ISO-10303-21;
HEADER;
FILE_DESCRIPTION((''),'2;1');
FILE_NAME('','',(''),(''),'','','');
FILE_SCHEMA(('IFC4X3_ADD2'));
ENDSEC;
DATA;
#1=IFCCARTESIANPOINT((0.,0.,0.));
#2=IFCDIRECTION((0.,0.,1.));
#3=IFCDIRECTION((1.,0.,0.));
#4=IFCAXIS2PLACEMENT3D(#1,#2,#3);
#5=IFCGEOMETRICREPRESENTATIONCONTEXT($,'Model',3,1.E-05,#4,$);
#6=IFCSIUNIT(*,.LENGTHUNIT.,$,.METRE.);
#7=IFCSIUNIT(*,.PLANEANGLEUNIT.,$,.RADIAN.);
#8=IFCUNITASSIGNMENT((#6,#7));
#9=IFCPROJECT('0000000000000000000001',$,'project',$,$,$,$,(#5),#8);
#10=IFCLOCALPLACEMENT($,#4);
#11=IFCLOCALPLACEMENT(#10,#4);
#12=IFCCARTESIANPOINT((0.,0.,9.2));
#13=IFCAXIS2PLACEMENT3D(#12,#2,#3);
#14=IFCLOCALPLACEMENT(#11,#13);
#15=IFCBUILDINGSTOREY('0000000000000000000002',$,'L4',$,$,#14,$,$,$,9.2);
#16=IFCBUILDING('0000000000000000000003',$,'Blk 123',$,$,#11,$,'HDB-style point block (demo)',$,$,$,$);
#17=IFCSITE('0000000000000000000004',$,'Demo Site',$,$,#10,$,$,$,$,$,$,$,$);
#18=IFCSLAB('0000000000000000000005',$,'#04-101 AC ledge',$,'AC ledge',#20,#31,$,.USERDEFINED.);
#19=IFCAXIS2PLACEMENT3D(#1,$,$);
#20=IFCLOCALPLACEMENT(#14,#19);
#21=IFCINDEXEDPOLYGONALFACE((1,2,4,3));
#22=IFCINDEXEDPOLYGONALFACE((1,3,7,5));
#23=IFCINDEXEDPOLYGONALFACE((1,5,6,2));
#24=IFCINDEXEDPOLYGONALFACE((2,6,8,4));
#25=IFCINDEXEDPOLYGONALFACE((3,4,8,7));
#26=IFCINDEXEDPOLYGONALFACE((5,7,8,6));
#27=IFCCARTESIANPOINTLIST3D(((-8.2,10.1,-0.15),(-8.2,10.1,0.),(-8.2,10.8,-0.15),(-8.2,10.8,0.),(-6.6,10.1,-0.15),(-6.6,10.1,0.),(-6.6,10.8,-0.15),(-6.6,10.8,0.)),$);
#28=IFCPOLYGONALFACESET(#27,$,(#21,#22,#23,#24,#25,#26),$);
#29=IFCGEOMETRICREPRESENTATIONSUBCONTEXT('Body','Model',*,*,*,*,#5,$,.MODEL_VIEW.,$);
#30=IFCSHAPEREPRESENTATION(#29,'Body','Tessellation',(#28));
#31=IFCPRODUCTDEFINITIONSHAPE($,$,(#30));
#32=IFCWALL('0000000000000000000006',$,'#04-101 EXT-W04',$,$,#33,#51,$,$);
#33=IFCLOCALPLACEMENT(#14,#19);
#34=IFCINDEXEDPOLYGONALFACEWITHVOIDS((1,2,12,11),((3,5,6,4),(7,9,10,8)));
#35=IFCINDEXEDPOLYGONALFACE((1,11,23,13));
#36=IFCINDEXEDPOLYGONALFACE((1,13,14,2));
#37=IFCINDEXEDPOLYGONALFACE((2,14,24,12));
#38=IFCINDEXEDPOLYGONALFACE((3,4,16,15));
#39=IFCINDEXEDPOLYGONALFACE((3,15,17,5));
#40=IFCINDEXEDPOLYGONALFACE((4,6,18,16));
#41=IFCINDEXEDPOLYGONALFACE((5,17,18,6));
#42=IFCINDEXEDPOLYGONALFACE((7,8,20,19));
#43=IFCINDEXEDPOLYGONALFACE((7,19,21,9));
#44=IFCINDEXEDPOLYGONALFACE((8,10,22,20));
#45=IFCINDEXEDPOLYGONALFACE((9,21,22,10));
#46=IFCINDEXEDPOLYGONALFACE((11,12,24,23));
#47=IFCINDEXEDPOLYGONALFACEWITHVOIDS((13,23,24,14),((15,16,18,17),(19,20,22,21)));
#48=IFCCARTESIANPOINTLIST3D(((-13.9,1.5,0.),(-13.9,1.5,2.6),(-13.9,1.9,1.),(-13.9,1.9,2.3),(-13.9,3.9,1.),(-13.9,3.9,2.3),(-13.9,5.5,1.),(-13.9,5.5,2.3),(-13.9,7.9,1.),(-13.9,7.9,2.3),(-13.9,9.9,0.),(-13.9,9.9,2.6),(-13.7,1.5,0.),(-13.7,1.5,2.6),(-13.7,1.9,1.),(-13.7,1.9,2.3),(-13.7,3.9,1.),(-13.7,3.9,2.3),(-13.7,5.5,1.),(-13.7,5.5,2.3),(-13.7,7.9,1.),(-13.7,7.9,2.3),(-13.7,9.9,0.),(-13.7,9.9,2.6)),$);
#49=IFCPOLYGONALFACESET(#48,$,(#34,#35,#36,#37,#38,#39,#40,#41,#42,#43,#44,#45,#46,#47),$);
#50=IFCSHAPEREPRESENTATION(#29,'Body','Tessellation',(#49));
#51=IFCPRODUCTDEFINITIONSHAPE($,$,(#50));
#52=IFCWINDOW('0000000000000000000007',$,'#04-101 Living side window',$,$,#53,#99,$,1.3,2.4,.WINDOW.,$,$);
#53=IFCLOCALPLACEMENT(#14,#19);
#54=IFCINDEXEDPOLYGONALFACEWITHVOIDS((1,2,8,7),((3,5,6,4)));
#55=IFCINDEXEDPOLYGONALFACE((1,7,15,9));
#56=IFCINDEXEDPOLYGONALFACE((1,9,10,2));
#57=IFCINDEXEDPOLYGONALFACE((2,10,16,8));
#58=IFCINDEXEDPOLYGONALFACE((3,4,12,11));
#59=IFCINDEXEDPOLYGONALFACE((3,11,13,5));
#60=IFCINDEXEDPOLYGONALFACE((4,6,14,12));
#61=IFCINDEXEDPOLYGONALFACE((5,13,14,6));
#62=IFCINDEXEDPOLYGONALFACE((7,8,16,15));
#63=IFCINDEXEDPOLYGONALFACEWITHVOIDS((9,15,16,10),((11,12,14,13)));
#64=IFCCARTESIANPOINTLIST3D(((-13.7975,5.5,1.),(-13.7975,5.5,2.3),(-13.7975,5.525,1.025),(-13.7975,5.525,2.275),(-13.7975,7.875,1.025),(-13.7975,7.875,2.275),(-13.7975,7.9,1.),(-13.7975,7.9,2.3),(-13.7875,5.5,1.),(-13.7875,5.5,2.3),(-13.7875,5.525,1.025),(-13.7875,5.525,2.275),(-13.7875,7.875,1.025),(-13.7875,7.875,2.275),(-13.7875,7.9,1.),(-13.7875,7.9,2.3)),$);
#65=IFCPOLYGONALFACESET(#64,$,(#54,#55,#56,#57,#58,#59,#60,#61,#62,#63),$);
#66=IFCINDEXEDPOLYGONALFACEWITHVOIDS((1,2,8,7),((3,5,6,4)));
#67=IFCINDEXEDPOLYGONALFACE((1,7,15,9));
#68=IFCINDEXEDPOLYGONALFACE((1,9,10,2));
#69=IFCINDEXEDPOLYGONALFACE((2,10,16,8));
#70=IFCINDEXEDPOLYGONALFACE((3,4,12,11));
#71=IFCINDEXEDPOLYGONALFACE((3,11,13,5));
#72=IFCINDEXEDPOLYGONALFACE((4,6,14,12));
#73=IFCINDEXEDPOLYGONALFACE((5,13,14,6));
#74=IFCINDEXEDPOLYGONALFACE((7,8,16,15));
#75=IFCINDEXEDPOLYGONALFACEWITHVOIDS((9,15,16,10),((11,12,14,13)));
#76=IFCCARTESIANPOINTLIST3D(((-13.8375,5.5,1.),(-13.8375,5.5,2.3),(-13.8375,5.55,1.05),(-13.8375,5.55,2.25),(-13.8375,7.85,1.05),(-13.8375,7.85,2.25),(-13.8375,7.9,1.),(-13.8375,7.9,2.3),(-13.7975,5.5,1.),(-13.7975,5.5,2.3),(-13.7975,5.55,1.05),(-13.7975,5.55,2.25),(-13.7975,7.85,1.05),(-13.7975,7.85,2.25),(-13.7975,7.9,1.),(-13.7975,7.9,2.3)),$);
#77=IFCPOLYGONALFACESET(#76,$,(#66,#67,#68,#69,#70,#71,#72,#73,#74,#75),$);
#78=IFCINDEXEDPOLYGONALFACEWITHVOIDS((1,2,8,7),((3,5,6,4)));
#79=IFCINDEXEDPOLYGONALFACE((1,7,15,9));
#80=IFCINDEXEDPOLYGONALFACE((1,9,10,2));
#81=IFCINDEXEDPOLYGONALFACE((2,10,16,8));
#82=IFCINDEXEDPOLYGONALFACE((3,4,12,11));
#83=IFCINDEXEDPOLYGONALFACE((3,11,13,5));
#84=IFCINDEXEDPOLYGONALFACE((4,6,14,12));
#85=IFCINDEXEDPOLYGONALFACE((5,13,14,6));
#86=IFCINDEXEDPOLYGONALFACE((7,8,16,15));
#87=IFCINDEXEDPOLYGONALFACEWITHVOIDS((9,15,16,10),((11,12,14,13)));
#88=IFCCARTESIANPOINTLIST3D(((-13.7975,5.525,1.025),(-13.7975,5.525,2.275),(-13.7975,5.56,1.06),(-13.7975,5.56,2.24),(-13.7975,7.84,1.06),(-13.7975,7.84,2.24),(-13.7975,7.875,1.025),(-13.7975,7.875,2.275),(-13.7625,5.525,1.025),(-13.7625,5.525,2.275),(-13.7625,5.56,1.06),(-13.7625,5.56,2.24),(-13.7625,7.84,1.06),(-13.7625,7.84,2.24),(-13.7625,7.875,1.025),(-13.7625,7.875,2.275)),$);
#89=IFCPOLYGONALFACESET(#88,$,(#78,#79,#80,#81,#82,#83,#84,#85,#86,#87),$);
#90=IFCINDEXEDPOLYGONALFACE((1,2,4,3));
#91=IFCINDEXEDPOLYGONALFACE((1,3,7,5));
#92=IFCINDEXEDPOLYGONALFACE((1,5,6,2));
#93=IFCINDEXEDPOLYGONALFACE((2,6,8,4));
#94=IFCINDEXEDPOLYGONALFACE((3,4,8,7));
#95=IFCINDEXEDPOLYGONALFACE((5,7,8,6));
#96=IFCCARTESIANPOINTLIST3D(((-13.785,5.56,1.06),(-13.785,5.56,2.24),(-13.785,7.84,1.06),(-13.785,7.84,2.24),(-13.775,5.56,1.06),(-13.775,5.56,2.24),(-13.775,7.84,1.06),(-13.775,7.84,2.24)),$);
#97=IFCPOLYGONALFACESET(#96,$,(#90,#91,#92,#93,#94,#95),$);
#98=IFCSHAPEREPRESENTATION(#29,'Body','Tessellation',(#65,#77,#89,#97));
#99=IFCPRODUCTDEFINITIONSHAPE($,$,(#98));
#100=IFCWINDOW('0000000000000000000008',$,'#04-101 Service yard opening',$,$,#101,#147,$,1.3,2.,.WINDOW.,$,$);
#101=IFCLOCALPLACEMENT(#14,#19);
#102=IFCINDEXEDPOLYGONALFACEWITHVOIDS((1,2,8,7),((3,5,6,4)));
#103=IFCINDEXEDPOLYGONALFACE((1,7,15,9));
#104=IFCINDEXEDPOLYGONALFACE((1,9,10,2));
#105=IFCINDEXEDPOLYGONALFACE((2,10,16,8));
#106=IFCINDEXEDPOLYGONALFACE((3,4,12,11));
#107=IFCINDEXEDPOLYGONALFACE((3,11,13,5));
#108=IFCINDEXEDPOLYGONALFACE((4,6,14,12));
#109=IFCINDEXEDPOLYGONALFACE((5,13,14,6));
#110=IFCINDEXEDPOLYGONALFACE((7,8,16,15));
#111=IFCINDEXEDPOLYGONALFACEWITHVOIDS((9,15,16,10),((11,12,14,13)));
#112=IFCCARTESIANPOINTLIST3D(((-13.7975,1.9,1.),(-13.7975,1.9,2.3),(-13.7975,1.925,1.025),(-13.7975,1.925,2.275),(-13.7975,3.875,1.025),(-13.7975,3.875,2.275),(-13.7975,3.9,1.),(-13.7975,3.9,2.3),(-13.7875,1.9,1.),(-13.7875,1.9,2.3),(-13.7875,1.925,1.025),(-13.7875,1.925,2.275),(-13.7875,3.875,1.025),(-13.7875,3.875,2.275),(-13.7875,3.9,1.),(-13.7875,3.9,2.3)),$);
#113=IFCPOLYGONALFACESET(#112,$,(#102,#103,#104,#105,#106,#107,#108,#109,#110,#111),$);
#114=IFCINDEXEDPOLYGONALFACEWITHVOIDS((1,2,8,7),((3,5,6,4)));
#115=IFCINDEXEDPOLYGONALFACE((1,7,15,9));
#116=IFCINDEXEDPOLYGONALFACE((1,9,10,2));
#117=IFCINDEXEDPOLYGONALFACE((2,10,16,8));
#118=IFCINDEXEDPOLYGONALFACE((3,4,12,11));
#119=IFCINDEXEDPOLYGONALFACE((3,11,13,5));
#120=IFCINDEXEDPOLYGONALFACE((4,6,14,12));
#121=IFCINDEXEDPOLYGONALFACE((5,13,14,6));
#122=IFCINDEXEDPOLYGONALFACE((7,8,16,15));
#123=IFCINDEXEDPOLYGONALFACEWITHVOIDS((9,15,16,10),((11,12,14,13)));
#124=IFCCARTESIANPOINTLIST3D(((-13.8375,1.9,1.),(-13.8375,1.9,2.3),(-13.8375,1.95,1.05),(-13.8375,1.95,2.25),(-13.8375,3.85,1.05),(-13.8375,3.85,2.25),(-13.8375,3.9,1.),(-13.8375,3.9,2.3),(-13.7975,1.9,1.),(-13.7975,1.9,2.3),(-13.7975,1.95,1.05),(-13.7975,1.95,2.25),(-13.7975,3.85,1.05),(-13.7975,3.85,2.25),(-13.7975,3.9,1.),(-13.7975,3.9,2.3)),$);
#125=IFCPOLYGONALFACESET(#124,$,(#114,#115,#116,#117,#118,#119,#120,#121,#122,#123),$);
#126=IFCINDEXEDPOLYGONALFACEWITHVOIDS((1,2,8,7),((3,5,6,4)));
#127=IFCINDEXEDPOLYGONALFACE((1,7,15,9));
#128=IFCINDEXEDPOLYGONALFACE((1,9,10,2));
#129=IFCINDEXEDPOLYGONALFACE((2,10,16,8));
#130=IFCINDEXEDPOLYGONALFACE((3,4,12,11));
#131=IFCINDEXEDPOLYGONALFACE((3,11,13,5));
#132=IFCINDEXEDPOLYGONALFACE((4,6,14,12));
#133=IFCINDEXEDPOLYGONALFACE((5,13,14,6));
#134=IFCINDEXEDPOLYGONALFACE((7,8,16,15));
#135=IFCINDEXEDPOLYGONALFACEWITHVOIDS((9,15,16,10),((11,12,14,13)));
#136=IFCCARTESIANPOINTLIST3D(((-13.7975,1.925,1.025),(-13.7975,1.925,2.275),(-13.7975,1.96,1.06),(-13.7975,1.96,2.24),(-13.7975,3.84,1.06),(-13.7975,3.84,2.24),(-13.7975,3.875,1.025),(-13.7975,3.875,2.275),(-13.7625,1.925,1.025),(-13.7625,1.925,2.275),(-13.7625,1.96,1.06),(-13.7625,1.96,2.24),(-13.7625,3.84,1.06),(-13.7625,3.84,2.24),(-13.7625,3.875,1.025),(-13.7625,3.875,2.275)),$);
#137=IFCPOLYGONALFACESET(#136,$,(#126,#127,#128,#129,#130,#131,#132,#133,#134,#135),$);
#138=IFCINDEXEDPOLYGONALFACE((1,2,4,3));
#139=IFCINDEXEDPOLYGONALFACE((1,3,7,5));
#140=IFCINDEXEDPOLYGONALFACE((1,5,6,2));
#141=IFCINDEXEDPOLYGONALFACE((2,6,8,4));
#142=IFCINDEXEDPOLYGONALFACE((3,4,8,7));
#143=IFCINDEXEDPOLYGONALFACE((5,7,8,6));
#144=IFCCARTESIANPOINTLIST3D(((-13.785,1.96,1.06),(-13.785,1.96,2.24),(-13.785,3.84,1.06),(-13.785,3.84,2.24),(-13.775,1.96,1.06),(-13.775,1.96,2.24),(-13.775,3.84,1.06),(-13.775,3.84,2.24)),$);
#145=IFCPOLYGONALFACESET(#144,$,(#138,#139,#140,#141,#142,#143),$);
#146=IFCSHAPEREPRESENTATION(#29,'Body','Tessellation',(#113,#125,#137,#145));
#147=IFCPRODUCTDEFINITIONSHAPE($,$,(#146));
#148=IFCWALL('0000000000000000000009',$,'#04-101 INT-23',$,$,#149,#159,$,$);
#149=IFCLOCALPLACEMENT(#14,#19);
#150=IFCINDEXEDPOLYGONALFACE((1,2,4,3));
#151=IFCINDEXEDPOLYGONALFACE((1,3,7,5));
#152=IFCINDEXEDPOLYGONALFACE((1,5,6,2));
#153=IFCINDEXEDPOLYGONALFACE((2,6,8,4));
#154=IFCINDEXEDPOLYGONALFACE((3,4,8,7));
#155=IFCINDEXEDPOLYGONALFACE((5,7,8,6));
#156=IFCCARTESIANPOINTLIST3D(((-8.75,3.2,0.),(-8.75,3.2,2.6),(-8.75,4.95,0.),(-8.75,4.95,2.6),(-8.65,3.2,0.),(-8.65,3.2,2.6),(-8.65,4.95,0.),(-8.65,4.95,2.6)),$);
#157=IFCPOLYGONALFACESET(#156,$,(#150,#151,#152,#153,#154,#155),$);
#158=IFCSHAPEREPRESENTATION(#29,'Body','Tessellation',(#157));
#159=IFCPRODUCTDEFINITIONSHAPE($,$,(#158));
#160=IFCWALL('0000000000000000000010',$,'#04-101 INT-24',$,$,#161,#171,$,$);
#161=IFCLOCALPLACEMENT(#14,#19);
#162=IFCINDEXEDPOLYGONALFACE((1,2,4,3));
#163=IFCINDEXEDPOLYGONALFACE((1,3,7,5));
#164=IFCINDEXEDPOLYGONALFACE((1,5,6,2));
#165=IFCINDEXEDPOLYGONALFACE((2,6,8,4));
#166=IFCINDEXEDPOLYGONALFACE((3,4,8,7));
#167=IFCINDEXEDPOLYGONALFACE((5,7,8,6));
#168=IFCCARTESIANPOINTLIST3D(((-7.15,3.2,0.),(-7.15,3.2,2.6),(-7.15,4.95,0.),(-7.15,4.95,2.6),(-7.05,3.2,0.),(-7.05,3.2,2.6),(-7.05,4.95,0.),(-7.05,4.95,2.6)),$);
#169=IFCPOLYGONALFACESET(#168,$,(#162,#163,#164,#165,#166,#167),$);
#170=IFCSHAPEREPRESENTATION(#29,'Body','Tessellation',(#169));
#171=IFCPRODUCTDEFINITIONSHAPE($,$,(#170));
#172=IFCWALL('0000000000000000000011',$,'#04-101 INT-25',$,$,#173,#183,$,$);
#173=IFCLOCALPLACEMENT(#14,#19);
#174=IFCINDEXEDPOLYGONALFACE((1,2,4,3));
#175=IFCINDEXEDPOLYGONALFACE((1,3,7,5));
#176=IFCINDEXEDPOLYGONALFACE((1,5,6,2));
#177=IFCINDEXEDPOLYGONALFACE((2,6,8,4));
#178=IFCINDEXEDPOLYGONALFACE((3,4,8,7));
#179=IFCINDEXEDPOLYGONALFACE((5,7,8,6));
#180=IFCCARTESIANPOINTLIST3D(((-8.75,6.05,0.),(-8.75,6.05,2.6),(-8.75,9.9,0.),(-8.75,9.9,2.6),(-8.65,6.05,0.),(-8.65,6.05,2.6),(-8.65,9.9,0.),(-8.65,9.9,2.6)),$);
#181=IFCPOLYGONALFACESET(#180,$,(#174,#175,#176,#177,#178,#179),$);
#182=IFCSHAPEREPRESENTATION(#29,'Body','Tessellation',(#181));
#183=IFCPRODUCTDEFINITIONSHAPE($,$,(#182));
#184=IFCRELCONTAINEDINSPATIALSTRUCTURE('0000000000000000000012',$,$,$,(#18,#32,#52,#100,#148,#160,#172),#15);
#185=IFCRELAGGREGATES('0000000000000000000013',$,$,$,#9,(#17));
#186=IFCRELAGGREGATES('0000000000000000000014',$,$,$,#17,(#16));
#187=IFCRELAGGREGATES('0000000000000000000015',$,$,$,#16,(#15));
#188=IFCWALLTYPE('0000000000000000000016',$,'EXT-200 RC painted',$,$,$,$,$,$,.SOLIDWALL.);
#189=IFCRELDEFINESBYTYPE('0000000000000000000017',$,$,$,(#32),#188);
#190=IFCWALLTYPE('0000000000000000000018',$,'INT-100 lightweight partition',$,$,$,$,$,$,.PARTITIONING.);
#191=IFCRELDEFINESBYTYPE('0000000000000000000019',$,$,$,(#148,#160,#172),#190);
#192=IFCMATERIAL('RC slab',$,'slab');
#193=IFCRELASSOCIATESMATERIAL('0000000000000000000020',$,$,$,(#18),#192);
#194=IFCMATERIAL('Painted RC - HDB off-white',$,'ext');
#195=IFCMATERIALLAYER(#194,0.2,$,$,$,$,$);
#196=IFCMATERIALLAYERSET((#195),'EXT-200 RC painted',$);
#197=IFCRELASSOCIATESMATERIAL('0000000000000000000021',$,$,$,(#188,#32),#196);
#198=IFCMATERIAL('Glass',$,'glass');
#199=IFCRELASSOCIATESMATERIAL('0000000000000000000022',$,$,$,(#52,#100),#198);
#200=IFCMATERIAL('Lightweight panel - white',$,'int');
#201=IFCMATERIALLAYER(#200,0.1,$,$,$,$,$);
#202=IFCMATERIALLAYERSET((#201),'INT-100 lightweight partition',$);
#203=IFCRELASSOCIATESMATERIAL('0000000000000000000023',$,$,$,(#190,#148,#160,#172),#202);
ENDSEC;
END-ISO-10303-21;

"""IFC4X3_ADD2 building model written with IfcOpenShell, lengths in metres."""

from ifc_helpers import new_model, si_unit, frame, origin, origin_with_axes, place, context, subcontext, project, spatial, polyline, line, indexed_curve, outline, extrude, material, layer, layer_set, layer_usage, type_object, element, fill, save


model = new_model("IFC4X3_ADD2")

# Units and contexts
model_context = context("Model", 3, precision=1e-05, world=origin_with_axes())
body_context = subcontext(model_context, "Body", "Model", "MODEL_VIEW")
ifc_project = project(units=[si_unit("LENGTHUNIT", "METRE"), si_unit("PLANEANGLEUNIT", "RADIAN")], contexts=[model_context])

# Site, building, storey
site_placement = place(None, origin_with_axes())
site = spatial("IfcSite", under=ifc_project, at=site_placement, Name="Demo Site")
building_placement = place(site_placement, origin_with_axes())
building = spatial("IfcBuilding", under=site, at=building_placement, Name="Blk 123", LongName="HDB-style point block (demo)")
storey_placement = place(building_placement, frame((0.0, 0.0, 9.2), z_axis=(0.0, 0.0, 1.0), x_axis=(1.0, 0.0, 0.0)))
storey = spatial("IfcBuildingStorey", under=building, at=storey_placement, Name="L4", Elevation=9.2)

# Slab
ifc_material_1 = material(Name="RC slab", Category="slab")
slab_placement = place(storey_placement, frame((-7.4, 10.45, -0.15), z_axis=(0.0, 0.0, 1.0), x_axis=(1.0, 0.0, 0.0)))
element("IfcSlab", 1, at=slab_placement, inside=storey, material=ifc_material_1, Name="#04-101 AC ledge", ObjectType="AC ledge", PredefinedType="USERDEFINED", context=body_context, shape_type="SweptSolid", body=[
    extrude(outline(polyline([(-0.8, -0.35), (0.8, -0.35), (0.8, 0.35), (-0.8, 0.35), (-0.8, -0.35)])), origin(), (0.0, 0.0, 1.0), 0.15),
])

# Shared definitions
ifc_material_2 = material(Name="Painted RC - HDB off-white", Category="ext")
ifc_layer_1 = layer(ifc_material_2, 0.2)
ifc_layer_set_1 = layer_set([ifc_layer_1], Name="EXT-200 RC painted")
ifc_layer_usage_1 = layer_usage(ifc_layer_set_1, "AXIS2", "POSITIVE", 0.0)
wall_type_1 = type_object("IfcWallType", Name="EXT-200 RC painted", PredefinedType="SOLIDWALL", material=ifc_layer_set_1)
ifc_material_3 = material(Name="Glass", Category="glass")

# Wall, openings, windows
wall_1_placement = place(storey_placement, frame((-13.9, 9.9, 0.0), z_axis=(0.0, 0.0, 1.0), x_axis=(0.0, -1.0, 0.0)))
wall_1 = element("IfcWall", 2, at=wall_1_placement, inside=storey, type_object=wall_type_1, material=ifc_layer_usage_1, Name="#04-101 EXT-W04", context=body_context, shape_type="SweptSolid", body=[
    extrude(outline(indexed_curve([(0.0, 0.0), (0.0, 0.2), (8.4, 0.2), (8.4, 0.0), (0.0, 0.0)], self_intersect=False)), origin_with_axes(), (0.0, 0.0, 1.0), 2.6),
])
opening_1_placement = place(wall_1_placement, frame((2.0, -0.1, 1.0), z_axis=(0.0, 0.0, 1.0), x_axis=(1.0, 0.0, 0.0)))
opening_1 = element("IfcOpeningElement", 3, at=opening_1_placement, cuts=wall_1, context=body_context, shape_type="SweptSolid", body=[
    extrude(outline(indexed_curve([(0.0, 0.0), (0.0, 0.4), (2.4, 0.4), (2.4, 0.0), (0.0, 0.0)], self_intersect=False)), origin_with_axes(), (0.0, 0.0, 1.0), 1.3),
])
opening_2_placement = place(wall_1_placement, frame((6.0, -0.1, 1.0), z_axis=(0.0, 0.0, 1.0), x_axis=(1.0, 0.0, 0.0)))
opening_2 = element("IfcOpeningElement", 4, at=opening_2_placement, cuts=wall_1, context=body_context, shape_type="SweptSolid", body=[
    extrude(outline(indexed_curve([(0.0, 0.0), (0.0, 0.4), (2.0, 0.4), (2.0, 0.0), (0.0, 0.0)], self_intersect=False)), origin_with_axes(), (0.0, 0.0, 1.0), 1.3),
])
window_1_placement = place(opening_1_placement, frame((0.0, 0.1125, 0.0), z_axis=(0.0, 0.0, 1.0), x_axis=(1.0, 0.0, 0.0)))
window_1 = element("IfcWindow", 5, at=window_1_placement, inside=storey, material=ifc_material_3, Name="#04-101 Living side window", OverallHeight=1.3, OverallWidth=2.4, PredefinedType="WINDOW", context=body_context, shape_type="SweptSolid", body=[
    extrude(outline(indexed_curve([(0.0, 0.0), (2.4, 0.0), (2.4, 1.3), (0.0, 1.3)], segments=[line(1, 2, 3, 4, 1)]), holes=[indexed_curve([(0.025, 0.025), (2.375, 0.025), (2.375, 1.275), (0.025, 1.275)], segments=[line(1, 2, 3, 4, 1)])]), frame((0.0, 0.09, 0.0), z_axis=(0.0, -1.0, 0.0), x_axis=(1.0, 0.0, 0.0)), (0.0, 0.0, -1.0), 0.01),
    extrude(outline(indexed_curve([(0.0, 0.0), (2.4, 0.0), (2.4, 1.3), (0.0, 1.3)], segments=[line(1, 2, 3, 4, 1)]), holes=[indexed_curve([(0.05, 0.05), (2.35, 0.05), (2.35, 1.25), (0.05, 1.25)], segments=[line(1, 2, 3, 4, 1)])]), frame((0.0, 0.05, 0.0), z_axis=(0.0, -1.0, 0.0), x_axis=(1.0, 0.0, 0.0)), (0.0, 0.0, -1.0), 0.04),
    extrude(outline(indexed_curve([(0.0, 0.0), (2.35, 0.0), (2.35, 1.25), (0.0, 1.25)], segments=[line(1, 2, 3, 4, 1)]), holes=[indexed_curve([(0.035, 0.035), (2.315, 0.035), (2.315, 1.215), (0.035, 1.215)], segments=[line(1, 2, 3, 4, 1)])]), frame((0.025, 0.09, 0.025), z_axis=(0.0, -1.0, 0.0), x_axis=(1.0, 0.0, 0.0)), (0.0, 0.0, -1.0), 0.035),
    extrude(outline(indexed_curve([(0.035, 0.035), (2.315, 0.035), (2.315, 1.215), (0.035, 1.215)], segments=[line(1, 2, 3, 4, 1)])), frame((0.025, 0.1025, 0.025), z_axis=(0.0, -1.0, 0.0), x_axis=(1.0, 0.0, 0.0)), (0.0, 0.0, -1.0), 0.01),
])
fill(opening_1, window_1)
window_2_placement = place(opening_2_placement, frame((0.0, 0.1125, 0.0), z_axis=(0.0, 0.0, 1.0), x_axis=(1.0, 0.0, 0.0)))
window_2 = element("IfcWindow", 6, at=window_2_placement, inside=storey, material=ifc_material_3, Name="#04-101 Service yard opening", OverallHeight=1.3, OverallWidth=2.0, PredefinedType="WINDOW", context=body_context, shape_type="SweptSolid", body=[
    extrude(outline(indexed_curve([(0.0, 0.0), (2.0, 0.0), (2.0, 1.3), (0.0, 1.3)], segments=[line(1, 2, 3, 4, 1)]), holes=[indexed_curve([(0.025, 0.025), (1.975, 0.025), (1.975, 1.275), (0.025, 1.275)], segments=[line(1, 2, 3, 4, 1)])]), frame((0.0, 0.09, 0.0), z_axis=(0.0, -1.0, 0.0), x_axis=(1.0, 0.0, 0.0)), (0.0, 0.0, -1.0), 0.01),
    extrude(outline(indexed_curve([(0.0, 0.0), (2.0, 0.0), (2.0, 1.3), (0.0, 1.3)], segments=[line(1, 2, 3, 4, 1)]), holes=[indexed_curve([(0.05, 0.05), (1.95, 0.05), (1.95, 1.25), (0.05, 1.25)], segments=[line(1, 2, 3, 4, 1)])]), frame((0.0, 0.05, 0.0), z_axis=(0.0, -1.0, 0.0), x_axis=(1.0, 0.0, 0.0)), (0.0, 0.0, -1.0), 0.04),
    extrude(outline(indexed_curve([(0.0, 0.0), (1.95, 0.0), (1.95, 1.25), (0.0, 1.25)], segments=[line(1, 2, 3, 4, 1)]), holes=[indexed_curve([(0.035, 0.035), (1.915, 0.035), (1.915, 1.215), (0.035, 1.215)], segments=[line(1, 2, 3, 4, 1)])]), frame((0.025, 0.09, 0.025), z_axis=(0.0, -1.0, 0.0), x_axis=(1.0, 0.0, 0.0)), (0.0, 0.0, -1.0), 0.035),
    extrude(outline(indexed_curve([(0.035, 0.035), (1.915, 0.035), (1.915, 1.215), (0.035, 1.215)], segments=[line(1, 2, 3, 4, 1)])), frame((0.025, 0.1025, 0.025), z_axis=(0.0, -1.0, 0.0), x_axis=(1.0, 0.0, 0.0)), (0.0, 0.0, -1.0), 0.01),
])
fill(opening_2, window_2)

# Walls
ifc_material_4 = material(Name="Lightweight panel - white", Category="int")
ifc_layer_2 = layer(ifc_material_4, 0.1)
ifc_layer_set_2 = layer_set([ifc_layer_2], Name="INT-100 lightweight partition")
ifc_layer_usage_2 = layer_usage(ifc_layer_set_2, "AXIS2", "POSITIVE", -0.05)
wall_type_2 = type_object("IfcWallType", Name="INT-100 lightweight partition", PredefinedType="PARTITIONING", material=ifc_layer_set_2)
for number, where, z_axis, x_axis, name in (
    (7, (-8.7, 3.2, 0.0), (0.0, 0.0, 1.0), (0.0, 1.0, 0.0), "#04-101 INT-23"),
    (8, (-7.1, 3.2, 0.0), (0.0, 0.0, 1.0), (0.0, 1.0, 0.0), "#04-101 INT-24"),
):
    element("IfcWall", number, at=place(storey_placement, frame(where, z_axis=z_axis, x_axis=x_axis)), inside=storey, type_object=wall_type_2, material=ifc_layer_usage_2, Name=name, context=body_context, shape_type="SweptSolid", body=[
        extrude(outline(indexed_curve([(0.0, 0.0), (0.0, 0.1), (1.75, 0.1), (1.75, 0.0), (0.0, 0.0)], self_intersect=False)), frame((0.0, -0.05, 0.0), z_axis=(0.0, 0.0, 1.0), x_axis=(1.0, 0.0, 0.0)), (0.0, 0.0, 1.0), 2.6),
    ])
wall_2_placement = place(storey_placement, frame((-8.7, 6.05, 0.0), z_axis=(0.0, 0.0, 1.0), x_axis=(0.0, 1.0, 0.0)))
element("IfcWall", 9, at=wall_2_placement, inside=storey, type_object=wall_type_2, material=ifc_layer_usage_2, Name="#04-101 INT-25", context=body_context, shape_type="SweptSolid", body=[
    extrude(outline(indexed_curve([(0.0, 0.0), (0.0, 0.1), (3.85, 0.1), (3.85, 0.0), (0.0, 0.0)], self_intersect=False)), frame((0.0, -0.05, 0.0), z_axis=(0.0, 0.0, 1.0), x_axis=(1.0, 0.0, 0.0)), (0.0, 0.0, 1.0), 2.6),
])

save(model, "model.ifc")
